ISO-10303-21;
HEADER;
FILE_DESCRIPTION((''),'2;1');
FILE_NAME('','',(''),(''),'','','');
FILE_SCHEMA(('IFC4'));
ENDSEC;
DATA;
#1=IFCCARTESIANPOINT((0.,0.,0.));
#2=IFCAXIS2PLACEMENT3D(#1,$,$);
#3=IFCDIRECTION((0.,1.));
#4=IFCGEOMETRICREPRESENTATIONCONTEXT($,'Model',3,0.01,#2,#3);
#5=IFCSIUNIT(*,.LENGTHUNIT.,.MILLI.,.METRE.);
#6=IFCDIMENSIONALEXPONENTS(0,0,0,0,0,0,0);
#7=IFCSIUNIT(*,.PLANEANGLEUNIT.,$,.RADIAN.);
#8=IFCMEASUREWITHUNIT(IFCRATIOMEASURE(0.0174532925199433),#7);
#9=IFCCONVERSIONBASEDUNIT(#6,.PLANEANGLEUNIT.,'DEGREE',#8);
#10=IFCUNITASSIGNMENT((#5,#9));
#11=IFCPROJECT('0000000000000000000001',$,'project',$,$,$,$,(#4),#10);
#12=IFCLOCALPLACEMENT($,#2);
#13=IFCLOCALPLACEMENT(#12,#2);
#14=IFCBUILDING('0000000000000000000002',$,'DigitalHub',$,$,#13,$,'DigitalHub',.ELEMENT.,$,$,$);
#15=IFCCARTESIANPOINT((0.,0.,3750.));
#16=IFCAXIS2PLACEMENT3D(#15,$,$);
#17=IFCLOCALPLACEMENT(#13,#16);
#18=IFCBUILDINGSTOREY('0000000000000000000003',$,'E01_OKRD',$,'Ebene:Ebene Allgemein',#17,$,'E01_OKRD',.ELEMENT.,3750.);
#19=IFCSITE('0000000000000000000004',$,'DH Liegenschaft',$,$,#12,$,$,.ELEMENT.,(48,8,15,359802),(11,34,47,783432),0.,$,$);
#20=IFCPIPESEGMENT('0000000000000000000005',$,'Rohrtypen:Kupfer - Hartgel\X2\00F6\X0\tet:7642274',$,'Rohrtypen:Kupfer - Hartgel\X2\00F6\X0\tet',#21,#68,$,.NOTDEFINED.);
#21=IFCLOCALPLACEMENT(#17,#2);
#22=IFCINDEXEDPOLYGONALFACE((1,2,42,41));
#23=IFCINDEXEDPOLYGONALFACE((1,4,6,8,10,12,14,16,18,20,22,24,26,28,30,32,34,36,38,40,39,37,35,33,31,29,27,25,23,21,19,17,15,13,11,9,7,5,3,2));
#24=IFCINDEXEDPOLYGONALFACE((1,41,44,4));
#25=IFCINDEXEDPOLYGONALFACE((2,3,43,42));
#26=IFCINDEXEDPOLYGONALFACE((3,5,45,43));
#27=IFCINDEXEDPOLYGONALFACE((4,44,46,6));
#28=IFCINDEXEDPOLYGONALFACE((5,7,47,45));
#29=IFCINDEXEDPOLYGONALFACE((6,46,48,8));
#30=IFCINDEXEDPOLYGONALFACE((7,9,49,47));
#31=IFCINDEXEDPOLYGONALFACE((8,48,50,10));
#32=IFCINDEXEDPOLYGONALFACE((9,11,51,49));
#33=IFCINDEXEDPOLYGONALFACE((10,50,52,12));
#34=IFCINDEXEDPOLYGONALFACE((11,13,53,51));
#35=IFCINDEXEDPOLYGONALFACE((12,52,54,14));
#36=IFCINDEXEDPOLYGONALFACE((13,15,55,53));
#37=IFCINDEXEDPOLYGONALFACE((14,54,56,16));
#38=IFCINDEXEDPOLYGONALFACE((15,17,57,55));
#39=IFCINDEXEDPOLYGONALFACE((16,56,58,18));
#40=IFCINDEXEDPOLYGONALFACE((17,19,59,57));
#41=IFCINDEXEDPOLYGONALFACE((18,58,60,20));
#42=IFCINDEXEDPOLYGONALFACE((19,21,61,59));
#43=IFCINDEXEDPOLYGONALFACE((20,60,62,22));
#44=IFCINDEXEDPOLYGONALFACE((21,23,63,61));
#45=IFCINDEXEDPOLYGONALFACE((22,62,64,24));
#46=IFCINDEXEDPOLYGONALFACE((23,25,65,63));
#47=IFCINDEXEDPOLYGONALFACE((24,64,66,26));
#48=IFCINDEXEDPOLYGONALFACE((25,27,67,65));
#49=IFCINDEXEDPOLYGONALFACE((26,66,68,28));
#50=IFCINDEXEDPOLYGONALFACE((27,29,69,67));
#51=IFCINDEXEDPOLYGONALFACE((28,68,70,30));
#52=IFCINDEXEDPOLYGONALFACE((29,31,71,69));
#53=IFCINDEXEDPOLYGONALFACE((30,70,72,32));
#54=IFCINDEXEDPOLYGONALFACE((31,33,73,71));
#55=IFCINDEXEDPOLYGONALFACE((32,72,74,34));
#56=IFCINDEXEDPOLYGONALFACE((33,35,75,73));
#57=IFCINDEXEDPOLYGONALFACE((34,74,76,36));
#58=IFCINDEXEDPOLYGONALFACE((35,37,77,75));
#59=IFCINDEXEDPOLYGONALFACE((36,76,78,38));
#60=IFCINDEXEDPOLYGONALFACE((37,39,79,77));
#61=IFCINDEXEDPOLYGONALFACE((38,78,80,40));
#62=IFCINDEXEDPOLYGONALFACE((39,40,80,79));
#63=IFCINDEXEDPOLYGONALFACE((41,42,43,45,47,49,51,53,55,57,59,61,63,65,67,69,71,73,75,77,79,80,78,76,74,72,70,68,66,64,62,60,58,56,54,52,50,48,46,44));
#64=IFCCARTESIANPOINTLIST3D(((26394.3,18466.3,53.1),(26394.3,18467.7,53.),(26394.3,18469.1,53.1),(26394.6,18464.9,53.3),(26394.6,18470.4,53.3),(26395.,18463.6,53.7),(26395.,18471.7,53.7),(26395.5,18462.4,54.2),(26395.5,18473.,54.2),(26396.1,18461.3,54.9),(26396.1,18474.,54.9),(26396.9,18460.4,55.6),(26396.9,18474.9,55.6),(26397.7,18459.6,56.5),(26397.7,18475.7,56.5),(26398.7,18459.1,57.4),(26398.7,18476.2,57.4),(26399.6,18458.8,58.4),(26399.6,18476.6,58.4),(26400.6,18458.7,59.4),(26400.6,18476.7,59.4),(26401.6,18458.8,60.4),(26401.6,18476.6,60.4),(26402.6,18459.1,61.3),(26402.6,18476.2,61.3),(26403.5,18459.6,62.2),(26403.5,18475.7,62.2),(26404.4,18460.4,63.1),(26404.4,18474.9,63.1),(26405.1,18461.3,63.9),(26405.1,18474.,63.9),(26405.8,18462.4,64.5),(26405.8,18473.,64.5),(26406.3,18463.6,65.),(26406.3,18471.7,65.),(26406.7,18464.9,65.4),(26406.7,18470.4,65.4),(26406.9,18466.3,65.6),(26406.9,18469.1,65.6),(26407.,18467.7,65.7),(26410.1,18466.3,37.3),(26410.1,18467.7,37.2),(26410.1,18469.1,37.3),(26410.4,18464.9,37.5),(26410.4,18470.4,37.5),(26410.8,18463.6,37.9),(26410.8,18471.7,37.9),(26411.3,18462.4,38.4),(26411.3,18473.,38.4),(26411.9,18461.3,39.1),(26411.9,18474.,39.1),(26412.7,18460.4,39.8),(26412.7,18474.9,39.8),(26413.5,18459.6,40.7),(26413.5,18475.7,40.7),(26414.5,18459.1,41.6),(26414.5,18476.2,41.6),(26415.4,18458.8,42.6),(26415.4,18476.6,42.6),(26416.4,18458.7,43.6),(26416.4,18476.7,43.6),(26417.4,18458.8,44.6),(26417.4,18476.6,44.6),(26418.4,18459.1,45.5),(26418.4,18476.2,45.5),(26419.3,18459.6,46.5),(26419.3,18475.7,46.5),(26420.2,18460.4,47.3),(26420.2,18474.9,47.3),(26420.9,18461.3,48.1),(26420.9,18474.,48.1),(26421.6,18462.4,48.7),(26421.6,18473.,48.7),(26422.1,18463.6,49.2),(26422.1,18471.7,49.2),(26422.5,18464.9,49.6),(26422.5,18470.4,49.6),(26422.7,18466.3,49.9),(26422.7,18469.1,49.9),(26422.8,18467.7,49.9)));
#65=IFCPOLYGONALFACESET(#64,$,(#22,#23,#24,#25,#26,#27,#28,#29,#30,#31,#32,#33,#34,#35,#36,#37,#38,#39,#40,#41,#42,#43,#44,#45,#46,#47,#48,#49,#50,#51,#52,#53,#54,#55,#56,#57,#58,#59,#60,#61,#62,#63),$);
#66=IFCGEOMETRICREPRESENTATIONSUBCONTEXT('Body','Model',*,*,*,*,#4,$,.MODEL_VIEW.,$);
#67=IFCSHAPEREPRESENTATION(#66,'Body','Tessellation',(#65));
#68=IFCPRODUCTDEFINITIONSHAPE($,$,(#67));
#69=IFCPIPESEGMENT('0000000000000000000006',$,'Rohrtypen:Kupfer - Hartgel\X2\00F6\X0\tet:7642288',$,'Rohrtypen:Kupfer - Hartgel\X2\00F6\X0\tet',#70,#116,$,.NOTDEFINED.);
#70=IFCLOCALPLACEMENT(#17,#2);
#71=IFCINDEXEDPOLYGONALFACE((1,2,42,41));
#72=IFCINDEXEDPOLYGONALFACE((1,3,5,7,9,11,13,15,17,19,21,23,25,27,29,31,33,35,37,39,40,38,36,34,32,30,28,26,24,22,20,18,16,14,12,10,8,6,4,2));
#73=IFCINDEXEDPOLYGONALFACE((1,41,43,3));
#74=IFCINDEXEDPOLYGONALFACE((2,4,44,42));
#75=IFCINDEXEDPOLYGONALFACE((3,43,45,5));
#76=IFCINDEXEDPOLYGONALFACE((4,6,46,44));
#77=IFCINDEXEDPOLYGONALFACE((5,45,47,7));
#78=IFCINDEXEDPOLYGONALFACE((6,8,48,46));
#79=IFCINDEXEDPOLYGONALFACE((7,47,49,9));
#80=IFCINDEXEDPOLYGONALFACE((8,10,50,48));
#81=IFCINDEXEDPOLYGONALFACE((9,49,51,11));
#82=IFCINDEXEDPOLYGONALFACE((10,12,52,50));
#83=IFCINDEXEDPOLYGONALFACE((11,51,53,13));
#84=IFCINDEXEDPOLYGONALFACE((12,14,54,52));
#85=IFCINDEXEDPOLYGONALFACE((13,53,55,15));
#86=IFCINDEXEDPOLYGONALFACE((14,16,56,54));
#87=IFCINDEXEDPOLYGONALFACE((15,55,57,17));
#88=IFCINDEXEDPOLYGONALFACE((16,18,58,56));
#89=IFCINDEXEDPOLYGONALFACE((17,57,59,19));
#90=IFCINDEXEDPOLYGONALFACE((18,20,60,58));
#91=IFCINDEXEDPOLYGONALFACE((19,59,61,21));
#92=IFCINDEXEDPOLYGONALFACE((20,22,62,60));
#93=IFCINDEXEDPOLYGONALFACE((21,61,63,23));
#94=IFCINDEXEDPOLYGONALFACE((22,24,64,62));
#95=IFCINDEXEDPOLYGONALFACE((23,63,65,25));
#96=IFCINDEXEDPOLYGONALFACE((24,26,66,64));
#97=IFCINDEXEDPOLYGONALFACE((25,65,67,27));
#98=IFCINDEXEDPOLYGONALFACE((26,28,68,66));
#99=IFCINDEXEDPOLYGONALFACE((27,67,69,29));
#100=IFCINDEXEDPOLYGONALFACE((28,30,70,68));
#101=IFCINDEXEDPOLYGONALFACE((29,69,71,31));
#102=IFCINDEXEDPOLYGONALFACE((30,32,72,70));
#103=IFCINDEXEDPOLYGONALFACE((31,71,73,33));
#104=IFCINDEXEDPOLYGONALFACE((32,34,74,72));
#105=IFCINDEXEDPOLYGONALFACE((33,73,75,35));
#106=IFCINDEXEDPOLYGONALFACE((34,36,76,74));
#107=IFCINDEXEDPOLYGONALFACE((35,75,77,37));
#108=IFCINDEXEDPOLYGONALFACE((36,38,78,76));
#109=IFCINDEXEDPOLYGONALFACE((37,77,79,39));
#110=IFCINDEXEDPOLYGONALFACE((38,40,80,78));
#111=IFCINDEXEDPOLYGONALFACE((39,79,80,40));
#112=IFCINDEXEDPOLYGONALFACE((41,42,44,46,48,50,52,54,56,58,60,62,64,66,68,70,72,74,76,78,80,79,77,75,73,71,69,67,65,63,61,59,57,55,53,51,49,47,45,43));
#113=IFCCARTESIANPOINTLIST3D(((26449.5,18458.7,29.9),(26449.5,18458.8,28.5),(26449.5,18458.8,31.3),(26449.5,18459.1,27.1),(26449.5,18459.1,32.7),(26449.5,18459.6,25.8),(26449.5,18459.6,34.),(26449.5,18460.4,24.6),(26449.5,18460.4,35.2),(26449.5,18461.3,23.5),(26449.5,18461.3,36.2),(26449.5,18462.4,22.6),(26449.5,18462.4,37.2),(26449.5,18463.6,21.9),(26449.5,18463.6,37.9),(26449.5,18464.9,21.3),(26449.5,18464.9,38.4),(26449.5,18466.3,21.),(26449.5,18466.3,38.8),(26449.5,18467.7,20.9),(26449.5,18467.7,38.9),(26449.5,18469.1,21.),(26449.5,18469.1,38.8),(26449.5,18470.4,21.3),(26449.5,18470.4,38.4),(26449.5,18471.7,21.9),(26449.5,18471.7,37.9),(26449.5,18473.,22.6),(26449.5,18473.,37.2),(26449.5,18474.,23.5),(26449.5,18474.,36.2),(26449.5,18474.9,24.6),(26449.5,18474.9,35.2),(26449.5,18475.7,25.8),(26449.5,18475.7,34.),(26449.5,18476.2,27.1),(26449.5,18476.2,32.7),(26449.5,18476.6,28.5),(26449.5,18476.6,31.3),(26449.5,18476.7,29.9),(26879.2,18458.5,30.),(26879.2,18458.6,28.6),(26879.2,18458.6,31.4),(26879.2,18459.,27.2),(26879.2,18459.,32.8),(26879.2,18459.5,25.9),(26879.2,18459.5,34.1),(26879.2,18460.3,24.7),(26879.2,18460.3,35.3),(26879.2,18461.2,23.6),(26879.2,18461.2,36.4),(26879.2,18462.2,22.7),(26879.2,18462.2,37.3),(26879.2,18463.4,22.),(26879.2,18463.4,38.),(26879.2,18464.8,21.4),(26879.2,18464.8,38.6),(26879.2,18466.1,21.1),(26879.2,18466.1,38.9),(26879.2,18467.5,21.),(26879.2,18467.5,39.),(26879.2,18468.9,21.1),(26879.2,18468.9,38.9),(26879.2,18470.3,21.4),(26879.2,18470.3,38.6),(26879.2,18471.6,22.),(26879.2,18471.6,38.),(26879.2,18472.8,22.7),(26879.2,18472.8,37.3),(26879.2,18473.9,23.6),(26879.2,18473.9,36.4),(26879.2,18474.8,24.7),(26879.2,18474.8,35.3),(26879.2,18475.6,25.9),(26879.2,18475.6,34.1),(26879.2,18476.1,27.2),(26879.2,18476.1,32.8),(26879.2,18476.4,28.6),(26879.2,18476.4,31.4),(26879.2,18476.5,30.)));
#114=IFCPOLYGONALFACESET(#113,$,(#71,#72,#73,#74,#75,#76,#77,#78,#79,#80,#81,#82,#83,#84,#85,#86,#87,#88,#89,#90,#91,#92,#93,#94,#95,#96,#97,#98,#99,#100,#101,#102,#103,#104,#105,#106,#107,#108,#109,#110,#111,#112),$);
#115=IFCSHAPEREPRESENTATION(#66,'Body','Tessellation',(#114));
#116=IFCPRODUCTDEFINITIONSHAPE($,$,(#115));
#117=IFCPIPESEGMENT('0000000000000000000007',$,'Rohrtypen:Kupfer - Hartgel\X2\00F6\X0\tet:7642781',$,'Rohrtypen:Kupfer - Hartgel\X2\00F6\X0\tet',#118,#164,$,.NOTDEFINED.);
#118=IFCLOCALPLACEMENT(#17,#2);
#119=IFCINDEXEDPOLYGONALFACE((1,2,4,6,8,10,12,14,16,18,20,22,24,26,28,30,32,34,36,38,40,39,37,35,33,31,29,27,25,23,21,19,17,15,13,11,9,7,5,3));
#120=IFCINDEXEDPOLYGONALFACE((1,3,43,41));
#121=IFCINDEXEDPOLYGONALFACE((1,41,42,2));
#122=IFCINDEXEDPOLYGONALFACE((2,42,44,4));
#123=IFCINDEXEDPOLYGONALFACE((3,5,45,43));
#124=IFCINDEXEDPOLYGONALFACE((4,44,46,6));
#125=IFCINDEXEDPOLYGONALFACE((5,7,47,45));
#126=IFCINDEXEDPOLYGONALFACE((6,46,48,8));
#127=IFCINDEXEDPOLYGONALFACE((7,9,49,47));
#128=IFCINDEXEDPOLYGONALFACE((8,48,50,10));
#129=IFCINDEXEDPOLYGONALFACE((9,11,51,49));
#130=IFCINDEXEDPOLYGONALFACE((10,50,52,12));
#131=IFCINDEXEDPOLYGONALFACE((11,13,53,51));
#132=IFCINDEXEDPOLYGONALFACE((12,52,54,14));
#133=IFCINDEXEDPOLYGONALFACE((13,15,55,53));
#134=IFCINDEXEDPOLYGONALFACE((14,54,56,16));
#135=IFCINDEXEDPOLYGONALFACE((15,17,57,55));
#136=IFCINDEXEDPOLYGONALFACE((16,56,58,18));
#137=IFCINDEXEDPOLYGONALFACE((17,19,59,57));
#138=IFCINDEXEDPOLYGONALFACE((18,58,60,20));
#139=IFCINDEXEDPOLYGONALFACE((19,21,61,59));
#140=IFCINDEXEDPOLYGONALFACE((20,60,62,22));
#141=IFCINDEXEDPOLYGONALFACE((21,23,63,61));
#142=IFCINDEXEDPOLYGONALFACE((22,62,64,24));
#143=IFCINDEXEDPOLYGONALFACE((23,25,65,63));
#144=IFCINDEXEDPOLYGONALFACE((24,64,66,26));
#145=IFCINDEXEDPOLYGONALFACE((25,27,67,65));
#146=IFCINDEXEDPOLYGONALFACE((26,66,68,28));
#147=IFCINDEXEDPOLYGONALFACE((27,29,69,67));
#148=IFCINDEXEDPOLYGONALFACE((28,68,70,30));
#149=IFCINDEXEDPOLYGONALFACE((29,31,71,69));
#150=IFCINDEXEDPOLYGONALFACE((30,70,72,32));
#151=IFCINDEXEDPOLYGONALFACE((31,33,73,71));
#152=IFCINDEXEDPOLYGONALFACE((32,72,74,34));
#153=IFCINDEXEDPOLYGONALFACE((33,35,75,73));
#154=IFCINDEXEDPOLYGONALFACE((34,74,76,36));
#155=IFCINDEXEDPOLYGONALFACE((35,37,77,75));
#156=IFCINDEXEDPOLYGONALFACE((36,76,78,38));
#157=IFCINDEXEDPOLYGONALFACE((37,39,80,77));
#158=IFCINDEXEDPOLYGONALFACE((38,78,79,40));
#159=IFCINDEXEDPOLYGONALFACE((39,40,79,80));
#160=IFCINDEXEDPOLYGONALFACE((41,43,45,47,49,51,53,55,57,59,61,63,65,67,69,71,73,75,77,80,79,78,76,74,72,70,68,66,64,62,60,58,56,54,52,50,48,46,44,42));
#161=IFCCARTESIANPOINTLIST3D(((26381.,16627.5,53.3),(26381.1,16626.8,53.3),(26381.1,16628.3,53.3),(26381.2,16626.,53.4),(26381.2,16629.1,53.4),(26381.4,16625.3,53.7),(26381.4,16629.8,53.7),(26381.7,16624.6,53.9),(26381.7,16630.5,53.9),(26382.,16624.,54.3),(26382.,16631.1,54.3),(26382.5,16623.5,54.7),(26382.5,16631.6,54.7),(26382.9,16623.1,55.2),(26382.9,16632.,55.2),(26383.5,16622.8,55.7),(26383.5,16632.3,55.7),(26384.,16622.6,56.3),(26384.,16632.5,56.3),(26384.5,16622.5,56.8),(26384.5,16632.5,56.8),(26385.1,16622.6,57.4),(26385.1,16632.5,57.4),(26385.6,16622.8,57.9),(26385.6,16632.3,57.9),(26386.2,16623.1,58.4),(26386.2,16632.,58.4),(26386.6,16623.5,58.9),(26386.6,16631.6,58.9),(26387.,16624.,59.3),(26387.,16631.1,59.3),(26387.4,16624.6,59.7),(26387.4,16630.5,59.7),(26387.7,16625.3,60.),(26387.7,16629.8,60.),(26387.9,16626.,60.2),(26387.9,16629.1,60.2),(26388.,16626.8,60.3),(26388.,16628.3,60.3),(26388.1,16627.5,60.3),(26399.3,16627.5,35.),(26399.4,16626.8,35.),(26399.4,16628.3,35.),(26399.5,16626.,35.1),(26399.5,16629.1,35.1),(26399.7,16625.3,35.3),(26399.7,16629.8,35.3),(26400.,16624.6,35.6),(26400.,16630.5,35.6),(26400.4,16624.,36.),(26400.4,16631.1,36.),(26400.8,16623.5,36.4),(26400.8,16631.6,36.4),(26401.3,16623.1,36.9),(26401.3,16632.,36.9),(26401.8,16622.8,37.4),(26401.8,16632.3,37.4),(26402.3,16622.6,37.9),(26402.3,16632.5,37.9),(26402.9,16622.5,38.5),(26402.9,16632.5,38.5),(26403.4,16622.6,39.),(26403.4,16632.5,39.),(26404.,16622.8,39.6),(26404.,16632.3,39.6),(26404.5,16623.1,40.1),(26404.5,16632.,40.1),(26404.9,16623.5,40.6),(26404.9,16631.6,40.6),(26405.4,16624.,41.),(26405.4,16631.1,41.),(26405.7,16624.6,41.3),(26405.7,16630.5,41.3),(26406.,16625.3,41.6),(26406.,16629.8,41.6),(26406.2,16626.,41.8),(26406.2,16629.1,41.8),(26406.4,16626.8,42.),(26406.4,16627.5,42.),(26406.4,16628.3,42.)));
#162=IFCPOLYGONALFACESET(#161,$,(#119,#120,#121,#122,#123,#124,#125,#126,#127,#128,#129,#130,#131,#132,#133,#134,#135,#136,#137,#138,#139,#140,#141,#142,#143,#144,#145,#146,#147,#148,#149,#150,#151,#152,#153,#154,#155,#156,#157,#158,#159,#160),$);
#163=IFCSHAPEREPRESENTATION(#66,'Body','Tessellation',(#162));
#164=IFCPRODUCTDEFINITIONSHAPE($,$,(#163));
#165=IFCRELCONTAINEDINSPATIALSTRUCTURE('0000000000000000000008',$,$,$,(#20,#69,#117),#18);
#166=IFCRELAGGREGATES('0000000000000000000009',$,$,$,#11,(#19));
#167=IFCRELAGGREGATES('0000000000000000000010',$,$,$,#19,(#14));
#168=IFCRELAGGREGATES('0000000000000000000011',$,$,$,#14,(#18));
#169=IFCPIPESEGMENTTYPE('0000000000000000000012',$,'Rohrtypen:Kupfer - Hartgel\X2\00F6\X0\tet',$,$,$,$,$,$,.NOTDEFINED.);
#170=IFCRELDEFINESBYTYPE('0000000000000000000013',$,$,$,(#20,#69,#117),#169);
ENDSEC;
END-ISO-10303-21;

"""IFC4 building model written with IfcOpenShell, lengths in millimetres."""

from ifc_helpers import new_model, entity, si_unit, converted_unit, direction, frame, origin, place, context, subcontext, project, spatial, indexed_curve, outline, extrude, type_object, element, save


model = new_model("IFC4")

# Units and contexts
model_context = context("Model", 3, precision=0.01, world=origin(), true_north=direction((0.0, 1.0)))
body_context = subcontext(model_context, "Body", "Model", "MODEL_VIEW")
ifc_project = project(units=[si_unit("LENGTHUNIT", "METRE", prefix="MILLI"), converted_unit("PLANEANGLEUNIT", "DEGREE", entity("IfcRatioMeasure", 0.0174532925199433), si_unit("PLANEANGLEUNIT", "RADIAN"), dimensions=[0, 0, 0, 0, 0, 0, 0])], contexts=[model_context])

# Site, building, storey
site_placement = place(None, origin())
site = spatial("IfcSite", under=ifc_project, at=site_placement, Name="DH Liegenschaft", CompositionType="ELEMENT", RefLatitude=(48, 8, 15, 359802), RefLongitude=(11, 34, 47, 783432), RefElevation=0.0)
building_placement = place(site_placement, origin())
building = spatial("IfcBuilding", under=site, at=building_placement, Name="DigitalHub", LongName="DigitalHub", CompositionType="ELEMENT")
storey_placement = place(building_placement, frame((0.0, 0.0, 3750.0)))
storey = spatial("IfcBuildingStorey", under=building, at=storey_placement, Name="E01_OKRD", ObjectType="Ebene:Ebene Allgemein", LongName="E01_OKRD", CompositionType="ELEMENT", Elevation=3750.0)

# Pipe segments
pipe_segment_type = type_object("IfcPipeSegmentType", Name="Rohrtypen:Kupfer - Hartgelötet", PredefinedType="NOTDEFINED")
pipe_segment_1_placement = place(storey_placement, frame((26392.7, 18457.1, 35.6)))
element("IfcPipeSegment", 1, at=pipe_segment_1_placement, inside=storey, type_object=pipe_segment_type, Name="Rohrtypen:Kupfer - Hartgelötet:7642274", ObjectType="Rohrtypen:Kupfer - Hartgelötet", PredefinedType="NOTDEFINED", context=body_context, shape_type="SweptSolid", body=[
    extrude(outline(indexed_curve([(9.0, 0.0), (8.9, 1.4), (8.6, 2.8), (8.0, 4.1), (7.3, 5.3), (6.4, 6.4), (5.3, 7.3), (4.1, 8.0), (2.8, 8.6), (1.4, 8.9), (0.0, 9.0), (-1.4, 8.9), (-2.8, 8.6), (-4.1, 8.0), (-5.3, 7.3), (-6.4, 6.4), (-7.3, 5.3), (-8.0, 4.1), (-8.6, 2.8), (-8.9, 1.4), (-9.0, 0.0), (-8.9, -1.4), (-8.6, -2.8), (-8.0, -4.1), (-7.3, -5.3), (-6.4, -6.4), (-5.3, -7.3), (-4.1, -8.0), (-2.8, -8.6), (-1.4, -8.9), (0.0, -9.0), (1.4, -8.9), (2.8, -8.6), (4.1, -8.0), (5.3, -7.3), (6.4, -6.4), (7.3, -5.3), (8.0, -4.1), (8.6, -2.8), (8.9, -1.4), (9.0, 0.0)], self_intersect=False)), frame((23.7, 10.6, 8.0), z_axis=(-0.707107, 0.0, 0.707107), x_axis=(0.0, -1.0, 0.0)), (0.0, 0.0, 1.0), 22.3),
])
pipe_segment_2_placement = place(storey_placement, frame((26449.5, 18456.9, 19.3)))
element("IfcPipeSegment", 2, at=pipe_segment_2_placement, inside=storey, type_object=pipe_segment_type, Name="Rohrtypen:Kupfer - Hartgelötet:7642288", ObjectType="Rohrtypen:Kupfer - Hartgelötet", PredefinedType="NOTDEFINED", context=body_context, shape_type="SweptSolid", body=[
    extrude(outline(indexed_curve([(9.0, 0.0), (8.9, 1.4), (8.6, 2.8), (8.0, 4.1), (7.3, 5.3), (6.4, 6.4), (5.3, 7.3), (4.1, 8.0), (2.8, 8.6), (1.4, 8.9), (0.0, 9.0), (-1.4, 8.9), (-2.8, 8.6), (-4.1, 8.0), (-5.3, 7.3), (-6.4, 6.4), (-7.3, 5.3), (-8.0, 4.1), (-8.6, 2.8), (-8.9, 1.4), (-9.0, 0.0), (-8.9, -1.4), (-8.6, -2.8), (-8.0, -4.1), (-7.3, -5.3), (-6.4, -6.4), (-5.3, -7.3), (-4.1, -8.0), (-2.8, -8.6), (-1.4, -8.9), (0.0, -9.0), (1.4, -8.9), (2.8, -8.6), (4.1, -8.0), (5.3, -7.3), (6.4, -6.4), (7.3, -5.3), (8.0, -4.1), (8.6, -2.8), (8.9, -1.4), (9.0, 0.0)], self_intersect=False)), frame((0.0, 10.7, 10.6), z_axis=(1.0, -0.000302, 0.000269), x_axis=(-0.000302, -1.0, 0.0)), (0.0, 0.0, 1.0), 429.7),
])
pipe_segment_3_placement = place(storey_placement, frame((26379.4, 16620.9, 33.4)))
element("IfcPipeSegment", 3, at=pipe_segment_3_placement, inside=storey, type_object=pipe_segment_type, Name="Rohrtypen:Kupfer - Hartgelötet:7642781", ObjectType="Rohrtypen:Kupfer - Hartgelötet", PredefinedType="NOTDEFINED", context=body_context, shape_type="SweptSolid", body=[
    extrude(outline(indexed_curve([(5.0, 0.0), (4.9, 0.8), (4.8, 1.5), (4.5, 2.3), (4.0, 2.9), (3.5, 3.5), (2.9, 4.0), (2.3, 4.5), (1.5, 4.8), (0.8, 4.9), (0.0, 5.0), (-0.8, 4.9), (-1.5, 4.8), (-2.3, 4.5), (-2.9, 4.0), (-3.5, 3.5), (-4.0, 2.9), (-4.5, 2.3), (-4.8, 1.5), (-4.9, 0.8), (-5.0, 0.0), (-4.9, -0.8), (-4.8, -1.5), (-4.5, -2.3), (-4.0, -2.9), (-3.5, -3.5), (-2.9, -4.0), (-2.3, -4.5), (-1.5, -4.8), (-0.8, -4.9), (0.0, -5.0), (0.8, -4.9), (1.5, -4.8), (2.3, -4.5), (2.9, -4.0), (3.5, -3.5), (4.0, -2.9), (4.5, -2.3), (4.8, -1.5), (4.9, -0.8), (5.0, 0.0)], self_intersect=False)), frame((5.1, 6.6, 23.5), z_axis=(0.707107, 0.0, -0.707107), x_axis=(0.0, -1.0, 0.0)), (0.0, 0.0, 1.0), 25.9),
])

save(model, "model.ifc")
